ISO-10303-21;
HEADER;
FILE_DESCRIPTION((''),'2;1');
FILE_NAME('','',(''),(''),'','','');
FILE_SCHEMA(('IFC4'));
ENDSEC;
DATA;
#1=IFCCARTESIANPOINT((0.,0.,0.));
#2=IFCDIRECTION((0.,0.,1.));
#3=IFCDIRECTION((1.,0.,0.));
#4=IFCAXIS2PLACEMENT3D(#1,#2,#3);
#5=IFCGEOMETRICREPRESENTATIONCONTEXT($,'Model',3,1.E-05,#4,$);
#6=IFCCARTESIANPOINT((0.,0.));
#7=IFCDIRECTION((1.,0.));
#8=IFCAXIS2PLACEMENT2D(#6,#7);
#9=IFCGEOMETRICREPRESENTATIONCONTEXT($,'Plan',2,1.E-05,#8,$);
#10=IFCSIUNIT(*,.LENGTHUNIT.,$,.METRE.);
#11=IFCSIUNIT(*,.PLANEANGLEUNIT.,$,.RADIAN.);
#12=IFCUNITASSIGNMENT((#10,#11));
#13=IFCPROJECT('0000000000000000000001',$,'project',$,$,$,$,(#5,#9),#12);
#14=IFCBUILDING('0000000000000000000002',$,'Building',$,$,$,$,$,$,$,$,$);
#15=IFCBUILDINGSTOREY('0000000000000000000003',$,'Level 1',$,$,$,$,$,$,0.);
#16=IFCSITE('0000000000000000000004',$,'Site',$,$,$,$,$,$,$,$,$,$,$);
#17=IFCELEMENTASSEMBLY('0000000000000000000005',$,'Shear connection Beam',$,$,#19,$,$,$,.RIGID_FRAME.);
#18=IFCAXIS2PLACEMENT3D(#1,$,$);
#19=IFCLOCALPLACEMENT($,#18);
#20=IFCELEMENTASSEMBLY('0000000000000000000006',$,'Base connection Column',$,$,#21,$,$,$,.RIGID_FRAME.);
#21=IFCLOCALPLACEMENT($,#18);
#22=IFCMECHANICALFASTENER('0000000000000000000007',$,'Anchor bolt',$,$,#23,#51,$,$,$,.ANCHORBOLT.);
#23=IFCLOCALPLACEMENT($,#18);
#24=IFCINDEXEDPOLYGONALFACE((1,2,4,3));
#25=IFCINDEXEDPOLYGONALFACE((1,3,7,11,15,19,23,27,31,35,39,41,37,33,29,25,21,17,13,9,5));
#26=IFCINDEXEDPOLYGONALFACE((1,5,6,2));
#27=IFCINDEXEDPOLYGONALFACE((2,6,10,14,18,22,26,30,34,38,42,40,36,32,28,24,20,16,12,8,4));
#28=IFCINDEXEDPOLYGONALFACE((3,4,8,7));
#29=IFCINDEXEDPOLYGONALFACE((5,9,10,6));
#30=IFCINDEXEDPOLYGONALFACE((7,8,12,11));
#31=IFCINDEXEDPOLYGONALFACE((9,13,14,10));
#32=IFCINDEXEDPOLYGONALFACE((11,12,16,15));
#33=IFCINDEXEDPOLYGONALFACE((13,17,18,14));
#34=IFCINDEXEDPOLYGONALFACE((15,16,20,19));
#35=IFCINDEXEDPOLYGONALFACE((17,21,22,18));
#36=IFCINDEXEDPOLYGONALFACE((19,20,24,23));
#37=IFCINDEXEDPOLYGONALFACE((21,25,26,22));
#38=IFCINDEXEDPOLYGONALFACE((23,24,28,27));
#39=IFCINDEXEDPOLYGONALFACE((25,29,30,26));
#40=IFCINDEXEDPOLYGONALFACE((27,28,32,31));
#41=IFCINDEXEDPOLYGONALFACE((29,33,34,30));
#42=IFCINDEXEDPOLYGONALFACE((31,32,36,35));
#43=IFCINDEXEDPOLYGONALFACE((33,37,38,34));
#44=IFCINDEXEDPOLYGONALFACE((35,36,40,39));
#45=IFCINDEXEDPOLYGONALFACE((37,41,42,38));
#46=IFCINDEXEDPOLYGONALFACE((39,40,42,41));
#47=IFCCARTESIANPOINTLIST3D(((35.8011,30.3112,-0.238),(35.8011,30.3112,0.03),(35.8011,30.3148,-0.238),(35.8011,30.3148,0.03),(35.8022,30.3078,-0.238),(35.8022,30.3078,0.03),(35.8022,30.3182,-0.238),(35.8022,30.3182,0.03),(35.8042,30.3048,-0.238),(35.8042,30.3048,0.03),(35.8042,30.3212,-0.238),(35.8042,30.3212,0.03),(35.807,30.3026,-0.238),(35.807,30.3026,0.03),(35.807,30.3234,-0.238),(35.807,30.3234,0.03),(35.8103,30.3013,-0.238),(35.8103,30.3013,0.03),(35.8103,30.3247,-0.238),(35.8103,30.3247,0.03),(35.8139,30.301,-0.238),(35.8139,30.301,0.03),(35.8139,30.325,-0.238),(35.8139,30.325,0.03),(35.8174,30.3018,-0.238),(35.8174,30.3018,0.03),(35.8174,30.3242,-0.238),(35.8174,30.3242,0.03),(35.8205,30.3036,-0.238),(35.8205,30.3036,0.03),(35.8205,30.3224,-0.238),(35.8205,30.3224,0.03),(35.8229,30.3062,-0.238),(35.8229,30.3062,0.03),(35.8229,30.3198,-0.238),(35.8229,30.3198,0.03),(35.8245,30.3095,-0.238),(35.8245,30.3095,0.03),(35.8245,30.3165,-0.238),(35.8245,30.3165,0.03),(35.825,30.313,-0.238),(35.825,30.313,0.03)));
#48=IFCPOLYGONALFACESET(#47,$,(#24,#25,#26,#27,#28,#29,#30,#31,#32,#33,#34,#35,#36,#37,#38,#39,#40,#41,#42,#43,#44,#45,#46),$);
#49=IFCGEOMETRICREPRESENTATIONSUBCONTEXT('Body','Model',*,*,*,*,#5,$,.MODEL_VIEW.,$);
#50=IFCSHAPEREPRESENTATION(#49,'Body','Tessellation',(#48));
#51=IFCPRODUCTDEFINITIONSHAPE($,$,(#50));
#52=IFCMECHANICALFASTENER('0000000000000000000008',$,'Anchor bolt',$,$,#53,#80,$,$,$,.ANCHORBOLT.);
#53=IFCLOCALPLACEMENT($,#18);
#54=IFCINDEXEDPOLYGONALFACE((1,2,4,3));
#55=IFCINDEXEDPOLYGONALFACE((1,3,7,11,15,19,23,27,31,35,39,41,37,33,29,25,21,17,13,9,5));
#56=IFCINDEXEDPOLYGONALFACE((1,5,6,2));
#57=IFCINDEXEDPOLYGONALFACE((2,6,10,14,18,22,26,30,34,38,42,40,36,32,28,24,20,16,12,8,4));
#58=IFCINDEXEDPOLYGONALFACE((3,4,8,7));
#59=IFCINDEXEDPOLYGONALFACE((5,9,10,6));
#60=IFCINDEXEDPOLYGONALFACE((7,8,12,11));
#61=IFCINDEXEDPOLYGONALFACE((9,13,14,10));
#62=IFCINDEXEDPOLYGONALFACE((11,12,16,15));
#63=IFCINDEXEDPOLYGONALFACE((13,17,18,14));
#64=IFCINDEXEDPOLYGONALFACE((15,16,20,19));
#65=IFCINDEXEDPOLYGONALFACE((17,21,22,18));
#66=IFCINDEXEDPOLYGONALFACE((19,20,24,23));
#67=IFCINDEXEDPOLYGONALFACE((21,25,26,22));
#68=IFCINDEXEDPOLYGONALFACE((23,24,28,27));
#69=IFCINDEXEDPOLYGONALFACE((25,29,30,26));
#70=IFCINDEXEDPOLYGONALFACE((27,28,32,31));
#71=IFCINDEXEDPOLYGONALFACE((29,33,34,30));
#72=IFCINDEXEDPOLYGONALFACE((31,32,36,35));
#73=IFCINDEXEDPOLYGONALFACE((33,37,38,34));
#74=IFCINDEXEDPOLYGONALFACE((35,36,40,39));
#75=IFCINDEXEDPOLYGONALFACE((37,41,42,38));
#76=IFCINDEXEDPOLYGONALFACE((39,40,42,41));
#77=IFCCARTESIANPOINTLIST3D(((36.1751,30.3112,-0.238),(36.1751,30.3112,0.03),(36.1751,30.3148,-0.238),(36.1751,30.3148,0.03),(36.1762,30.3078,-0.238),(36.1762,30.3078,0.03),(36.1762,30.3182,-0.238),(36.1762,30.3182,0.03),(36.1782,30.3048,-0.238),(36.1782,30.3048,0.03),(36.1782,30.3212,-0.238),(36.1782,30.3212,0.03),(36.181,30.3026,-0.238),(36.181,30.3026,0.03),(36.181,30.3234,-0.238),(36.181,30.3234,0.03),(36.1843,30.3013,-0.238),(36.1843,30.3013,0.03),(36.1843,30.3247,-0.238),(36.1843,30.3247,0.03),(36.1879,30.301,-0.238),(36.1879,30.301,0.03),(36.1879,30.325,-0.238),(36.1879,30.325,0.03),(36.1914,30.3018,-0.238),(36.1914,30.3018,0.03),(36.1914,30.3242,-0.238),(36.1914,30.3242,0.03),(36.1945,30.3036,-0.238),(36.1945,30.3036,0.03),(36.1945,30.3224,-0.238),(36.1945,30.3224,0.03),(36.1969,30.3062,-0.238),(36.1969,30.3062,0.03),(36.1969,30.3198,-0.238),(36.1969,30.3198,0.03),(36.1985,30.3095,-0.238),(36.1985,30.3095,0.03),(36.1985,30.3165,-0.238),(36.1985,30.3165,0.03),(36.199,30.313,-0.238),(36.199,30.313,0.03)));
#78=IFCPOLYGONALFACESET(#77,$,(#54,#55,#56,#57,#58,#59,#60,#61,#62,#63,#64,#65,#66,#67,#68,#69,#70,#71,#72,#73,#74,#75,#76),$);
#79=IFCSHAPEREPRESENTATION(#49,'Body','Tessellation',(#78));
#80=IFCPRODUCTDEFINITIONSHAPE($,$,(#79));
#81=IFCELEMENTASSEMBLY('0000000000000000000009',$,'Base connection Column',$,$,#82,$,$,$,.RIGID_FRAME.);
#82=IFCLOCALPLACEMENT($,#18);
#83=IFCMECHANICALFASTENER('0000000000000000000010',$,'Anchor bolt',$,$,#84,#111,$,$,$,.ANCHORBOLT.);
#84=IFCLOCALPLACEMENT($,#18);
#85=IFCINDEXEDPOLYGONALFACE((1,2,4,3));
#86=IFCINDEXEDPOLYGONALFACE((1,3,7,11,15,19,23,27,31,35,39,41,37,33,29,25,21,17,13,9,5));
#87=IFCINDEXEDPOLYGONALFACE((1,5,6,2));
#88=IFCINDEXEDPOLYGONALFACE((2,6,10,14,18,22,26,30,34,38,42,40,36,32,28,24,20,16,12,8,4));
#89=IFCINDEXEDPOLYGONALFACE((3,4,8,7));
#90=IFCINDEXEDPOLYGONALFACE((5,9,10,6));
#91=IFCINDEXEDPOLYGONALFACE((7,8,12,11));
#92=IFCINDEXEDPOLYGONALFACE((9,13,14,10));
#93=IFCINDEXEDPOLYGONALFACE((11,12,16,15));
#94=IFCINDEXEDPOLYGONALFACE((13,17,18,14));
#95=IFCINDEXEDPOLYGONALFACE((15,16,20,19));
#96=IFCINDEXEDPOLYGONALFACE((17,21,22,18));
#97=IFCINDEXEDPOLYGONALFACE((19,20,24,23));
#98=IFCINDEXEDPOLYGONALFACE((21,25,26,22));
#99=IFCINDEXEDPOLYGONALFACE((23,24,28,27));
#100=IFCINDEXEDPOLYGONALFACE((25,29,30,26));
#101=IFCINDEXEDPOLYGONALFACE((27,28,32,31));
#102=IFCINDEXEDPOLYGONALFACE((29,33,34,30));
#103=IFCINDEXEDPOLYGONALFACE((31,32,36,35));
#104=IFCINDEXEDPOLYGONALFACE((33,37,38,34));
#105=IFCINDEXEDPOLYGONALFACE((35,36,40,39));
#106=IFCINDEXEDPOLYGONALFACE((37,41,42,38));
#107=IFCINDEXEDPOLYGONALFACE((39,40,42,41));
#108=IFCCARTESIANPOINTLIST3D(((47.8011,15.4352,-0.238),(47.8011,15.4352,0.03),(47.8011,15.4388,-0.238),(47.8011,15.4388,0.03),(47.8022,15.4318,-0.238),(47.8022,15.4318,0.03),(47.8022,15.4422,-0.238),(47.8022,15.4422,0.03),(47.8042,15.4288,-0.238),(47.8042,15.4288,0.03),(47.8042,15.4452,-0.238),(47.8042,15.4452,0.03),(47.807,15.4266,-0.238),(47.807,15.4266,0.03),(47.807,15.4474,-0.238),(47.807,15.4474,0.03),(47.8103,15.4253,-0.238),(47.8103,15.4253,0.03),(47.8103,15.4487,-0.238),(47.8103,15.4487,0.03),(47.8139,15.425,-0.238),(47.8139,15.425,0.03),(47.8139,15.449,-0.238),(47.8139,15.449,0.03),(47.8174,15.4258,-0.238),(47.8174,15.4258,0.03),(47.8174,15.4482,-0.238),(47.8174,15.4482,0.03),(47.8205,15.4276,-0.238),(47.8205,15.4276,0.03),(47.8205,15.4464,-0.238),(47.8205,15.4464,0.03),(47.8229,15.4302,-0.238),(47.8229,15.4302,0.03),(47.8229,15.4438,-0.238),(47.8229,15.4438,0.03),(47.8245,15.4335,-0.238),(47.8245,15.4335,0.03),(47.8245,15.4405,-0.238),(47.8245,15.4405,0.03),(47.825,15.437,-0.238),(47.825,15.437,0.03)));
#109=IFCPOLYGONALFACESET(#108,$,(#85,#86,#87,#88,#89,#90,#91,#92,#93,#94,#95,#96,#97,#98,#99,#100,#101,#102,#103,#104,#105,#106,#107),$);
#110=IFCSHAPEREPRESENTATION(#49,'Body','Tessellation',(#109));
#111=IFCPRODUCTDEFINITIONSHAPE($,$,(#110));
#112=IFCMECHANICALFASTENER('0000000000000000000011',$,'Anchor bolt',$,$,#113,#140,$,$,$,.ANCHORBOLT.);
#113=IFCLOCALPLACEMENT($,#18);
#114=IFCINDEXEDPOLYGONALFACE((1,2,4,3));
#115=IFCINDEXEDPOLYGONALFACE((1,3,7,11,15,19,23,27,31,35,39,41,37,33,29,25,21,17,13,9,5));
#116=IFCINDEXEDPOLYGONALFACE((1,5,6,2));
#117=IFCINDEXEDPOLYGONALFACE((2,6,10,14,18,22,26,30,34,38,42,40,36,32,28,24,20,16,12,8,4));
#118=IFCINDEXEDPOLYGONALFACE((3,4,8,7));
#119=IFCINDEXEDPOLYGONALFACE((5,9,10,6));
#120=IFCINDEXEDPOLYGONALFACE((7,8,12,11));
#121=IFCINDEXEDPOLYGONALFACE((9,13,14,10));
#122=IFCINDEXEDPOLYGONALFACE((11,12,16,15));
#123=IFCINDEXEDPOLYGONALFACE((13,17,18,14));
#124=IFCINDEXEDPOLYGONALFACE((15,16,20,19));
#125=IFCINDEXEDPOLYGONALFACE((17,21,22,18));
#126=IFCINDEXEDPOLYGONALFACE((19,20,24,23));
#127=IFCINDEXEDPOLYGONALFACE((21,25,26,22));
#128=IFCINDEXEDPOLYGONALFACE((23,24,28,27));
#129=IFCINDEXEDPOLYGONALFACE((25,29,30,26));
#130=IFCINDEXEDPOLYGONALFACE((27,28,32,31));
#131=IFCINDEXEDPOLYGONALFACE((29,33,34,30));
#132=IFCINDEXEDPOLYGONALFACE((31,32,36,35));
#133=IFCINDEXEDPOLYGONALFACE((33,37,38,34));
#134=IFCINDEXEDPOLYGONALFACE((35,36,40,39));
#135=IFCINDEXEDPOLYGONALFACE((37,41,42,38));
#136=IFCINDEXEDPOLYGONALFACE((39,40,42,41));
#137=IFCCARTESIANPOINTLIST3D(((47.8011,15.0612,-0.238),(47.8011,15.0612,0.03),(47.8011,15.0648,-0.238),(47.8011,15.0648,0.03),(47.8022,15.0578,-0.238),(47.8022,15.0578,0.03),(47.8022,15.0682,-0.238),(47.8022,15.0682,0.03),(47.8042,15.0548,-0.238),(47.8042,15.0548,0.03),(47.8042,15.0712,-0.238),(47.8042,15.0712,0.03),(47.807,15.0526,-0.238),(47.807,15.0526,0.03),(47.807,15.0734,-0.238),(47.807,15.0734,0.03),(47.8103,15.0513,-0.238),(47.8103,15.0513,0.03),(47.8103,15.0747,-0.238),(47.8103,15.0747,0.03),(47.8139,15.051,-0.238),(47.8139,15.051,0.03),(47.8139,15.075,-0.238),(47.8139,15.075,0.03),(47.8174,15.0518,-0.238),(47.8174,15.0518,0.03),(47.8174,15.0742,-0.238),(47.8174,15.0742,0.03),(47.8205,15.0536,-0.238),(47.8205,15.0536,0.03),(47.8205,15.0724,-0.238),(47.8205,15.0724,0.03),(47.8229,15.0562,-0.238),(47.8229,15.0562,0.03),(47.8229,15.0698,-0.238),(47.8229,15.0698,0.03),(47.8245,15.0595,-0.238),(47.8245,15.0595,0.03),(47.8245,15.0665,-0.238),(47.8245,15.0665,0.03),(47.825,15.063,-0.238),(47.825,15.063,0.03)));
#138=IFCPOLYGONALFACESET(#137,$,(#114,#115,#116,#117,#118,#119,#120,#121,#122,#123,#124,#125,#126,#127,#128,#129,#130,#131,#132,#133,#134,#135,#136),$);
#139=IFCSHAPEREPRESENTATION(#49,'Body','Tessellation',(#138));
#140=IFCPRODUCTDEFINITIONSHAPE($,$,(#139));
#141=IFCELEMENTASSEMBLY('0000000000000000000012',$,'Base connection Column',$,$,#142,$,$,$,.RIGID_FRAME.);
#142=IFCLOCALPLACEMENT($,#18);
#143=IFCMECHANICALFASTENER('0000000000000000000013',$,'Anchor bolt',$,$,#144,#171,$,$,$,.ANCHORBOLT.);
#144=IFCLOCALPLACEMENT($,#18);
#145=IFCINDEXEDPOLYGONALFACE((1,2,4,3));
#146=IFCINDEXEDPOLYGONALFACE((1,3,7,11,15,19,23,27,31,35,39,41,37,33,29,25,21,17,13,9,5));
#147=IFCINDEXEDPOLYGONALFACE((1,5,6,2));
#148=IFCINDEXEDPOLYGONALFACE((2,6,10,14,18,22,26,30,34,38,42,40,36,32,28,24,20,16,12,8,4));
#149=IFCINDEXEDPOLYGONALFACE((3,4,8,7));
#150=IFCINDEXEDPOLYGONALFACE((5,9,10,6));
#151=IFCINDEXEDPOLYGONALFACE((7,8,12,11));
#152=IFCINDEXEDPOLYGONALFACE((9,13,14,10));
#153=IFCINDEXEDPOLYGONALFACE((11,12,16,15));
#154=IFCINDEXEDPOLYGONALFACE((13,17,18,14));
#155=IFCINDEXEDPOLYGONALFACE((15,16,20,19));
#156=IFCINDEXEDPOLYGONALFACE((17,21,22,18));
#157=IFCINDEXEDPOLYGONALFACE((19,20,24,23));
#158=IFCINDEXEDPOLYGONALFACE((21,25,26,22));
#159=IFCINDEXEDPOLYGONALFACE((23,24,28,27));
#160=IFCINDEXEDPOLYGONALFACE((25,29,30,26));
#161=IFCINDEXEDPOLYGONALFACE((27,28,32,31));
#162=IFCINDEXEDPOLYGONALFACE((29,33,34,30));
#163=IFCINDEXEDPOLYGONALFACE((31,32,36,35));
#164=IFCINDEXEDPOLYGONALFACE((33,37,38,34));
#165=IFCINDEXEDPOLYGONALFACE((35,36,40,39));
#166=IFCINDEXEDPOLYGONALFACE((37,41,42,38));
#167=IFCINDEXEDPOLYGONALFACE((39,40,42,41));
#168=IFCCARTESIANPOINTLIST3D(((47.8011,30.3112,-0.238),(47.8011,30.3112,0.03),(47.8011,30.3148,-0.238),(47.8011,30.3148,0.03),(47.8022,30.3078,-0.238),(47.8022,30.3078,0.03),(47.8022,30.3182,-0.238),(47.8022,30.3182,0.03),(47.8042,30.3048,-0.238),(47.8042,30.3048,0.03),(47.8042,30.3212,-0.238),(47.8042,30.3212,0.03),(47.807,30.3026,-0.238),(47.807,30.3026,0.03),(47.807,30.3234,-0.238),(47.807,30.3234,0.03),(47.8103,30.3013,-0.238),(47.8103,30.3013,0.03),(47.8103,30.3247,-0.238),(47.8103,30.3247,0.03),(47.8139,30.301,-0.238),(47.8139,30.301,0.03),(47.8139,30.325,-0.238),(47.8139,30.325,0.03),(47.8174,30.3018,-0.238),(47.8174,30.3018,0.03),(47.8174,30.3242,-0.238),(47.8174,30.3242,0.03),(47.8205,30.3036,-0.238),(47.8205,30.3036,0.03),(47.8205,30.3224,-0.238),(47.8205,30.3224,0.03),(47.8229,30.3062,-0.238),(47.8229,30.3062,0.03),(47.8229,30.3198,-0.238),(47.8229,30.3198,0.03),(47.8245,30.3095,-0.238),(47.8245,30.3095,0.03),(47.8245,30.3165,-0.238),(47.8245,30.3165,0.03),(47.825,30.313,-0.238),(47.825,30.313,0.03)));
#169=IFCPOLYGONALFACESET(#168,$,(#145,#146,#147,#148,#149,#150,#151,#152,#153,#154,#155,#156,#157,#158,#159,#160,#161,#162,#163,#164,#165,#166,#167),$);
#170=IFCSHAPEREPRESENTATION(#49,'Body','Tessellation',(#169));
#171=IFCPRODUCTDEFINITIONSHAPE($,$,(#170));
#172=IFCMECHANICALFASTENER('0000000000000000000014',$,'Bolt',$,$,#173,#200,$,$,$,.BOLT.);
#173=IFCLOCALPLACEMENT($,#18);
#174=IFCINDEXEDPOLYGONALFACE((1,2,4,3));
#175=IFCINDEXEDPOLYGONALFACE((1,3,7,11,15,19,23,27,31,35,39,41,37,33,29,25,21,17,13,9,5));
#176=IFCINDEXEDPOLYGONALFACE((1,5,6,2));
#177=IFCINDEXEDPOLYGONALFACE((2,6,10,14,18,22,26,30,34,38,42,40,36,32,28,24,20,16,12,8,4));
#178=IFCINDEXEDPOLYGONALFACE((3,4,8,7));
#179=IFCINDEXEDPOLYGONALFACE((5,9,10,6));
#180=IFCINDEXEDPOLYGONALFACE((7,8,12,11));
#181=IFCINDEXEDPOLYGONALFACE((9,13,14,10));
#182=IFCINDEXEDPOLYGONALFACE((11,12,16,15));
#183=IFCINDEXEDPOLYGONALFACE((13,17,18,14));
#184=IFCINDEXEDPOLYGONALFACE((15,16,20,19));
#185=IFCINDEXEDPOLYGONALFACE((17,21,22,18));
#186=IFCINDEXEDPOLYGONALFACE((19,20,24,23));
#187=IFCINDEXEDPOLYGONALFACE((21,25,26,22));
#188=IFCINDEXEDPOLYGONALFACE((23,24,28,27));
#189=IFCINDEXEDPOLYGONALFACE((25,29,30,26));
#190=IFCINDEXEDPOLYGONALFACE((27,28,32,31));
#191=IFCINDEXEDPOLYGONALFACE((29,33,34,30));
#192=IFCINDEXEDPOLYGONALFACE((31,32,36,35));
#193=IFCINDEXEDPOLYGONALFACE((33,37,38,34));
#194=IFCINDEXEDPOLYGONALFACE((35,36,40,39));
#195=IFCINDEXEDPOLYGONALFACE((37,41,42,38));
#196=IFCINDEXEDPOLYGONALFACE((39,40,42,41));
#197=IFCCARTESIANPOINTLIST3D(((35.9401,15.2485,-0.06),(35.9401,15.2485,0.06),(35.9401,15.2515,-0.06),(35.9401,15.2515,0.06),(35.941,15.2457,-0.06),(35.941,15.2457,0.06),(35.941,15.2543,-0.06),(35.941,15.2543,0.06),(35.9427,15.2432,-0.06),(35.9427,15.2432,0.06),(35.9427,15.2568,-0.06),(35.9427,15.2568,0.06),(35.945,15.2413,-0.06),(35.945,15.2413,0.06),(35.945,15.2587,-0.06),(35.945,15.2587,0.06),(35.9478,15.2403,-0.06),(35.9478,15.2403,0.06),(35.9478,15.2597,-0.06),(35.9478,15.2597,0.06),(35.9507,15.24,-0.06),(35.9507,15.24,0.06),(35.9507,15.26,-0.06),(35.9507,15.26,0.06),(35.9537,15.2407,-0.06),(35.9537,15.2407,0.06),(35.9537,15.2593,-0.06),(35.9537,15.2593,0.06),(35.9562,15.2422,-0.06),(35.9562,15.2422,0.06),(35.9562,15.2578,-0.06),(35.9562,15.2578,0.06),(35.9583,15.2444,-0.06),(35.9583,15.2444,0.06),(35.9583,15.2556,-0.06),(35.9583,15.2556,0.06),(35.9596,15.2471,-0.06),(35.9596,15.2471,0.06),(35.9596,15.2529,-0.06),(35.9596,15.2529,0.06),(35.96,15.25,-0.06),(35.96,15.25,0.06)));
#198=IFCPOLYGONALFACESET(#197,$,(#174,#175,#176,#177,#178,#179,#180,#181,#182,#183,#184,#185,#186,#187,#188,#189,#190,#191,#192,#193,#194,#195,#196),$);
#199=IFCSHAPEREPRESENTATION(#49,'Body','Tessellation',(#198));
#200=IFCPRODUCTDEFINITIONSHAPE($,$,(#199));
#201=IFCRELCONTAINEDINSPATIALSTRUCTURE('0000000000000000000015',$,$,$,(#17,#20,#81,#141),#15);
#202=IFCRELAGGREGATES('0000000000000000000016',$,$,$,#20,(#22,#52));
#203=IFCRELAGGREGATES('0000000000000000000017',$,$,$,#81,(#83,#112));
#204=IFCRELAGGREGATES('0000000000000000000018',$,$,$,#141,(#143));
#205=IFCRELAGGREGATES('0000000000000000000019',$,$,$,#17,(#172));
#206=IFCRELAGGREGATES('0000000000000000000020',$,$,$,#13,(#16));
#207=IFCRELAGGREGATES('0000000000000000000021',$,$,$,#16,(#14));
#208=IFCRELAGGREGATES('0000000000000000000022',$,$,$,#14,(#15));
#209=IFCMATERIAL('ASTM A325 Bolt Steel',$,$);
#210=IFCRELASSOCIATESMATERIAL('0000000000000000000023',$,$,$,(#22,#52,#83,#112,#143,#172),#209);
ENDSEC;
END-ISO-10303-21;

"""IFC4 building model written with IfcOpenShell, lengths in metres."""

from ifc_helpers import new_model, si_unit, frame, origin_with_axes, origin_2d, origin_2d_with_axis, place, context, subcontext, project, spatial, circle, extrude, material, element, aggregate, save


model = new_model("IFC4")

# Units and contexts
model_context = context("Model", 3, precision=1e-05, world=origin_with_axes())
plan_context = context("Plan", 2, precision=1e-05, world=origin_2d_with_axis())
body_context = subcontext(model_context, "Body", "Model", "MODEL_VIEW")
ifc_project = project(units=[si_unit("LENGTHUNIT", "METRE"), si_unit("PLANEANGLEUNIT", "RADIAN")], contexts=[model_context, plan_context])

# Site, building, storey
site = spatial("IfcSite", under=ifc_project, Name="Site")
building = spatial("IfcBuilding", under=site, Name="Building")
storey = spatial("IfcBuildingStorey", under=building, Name="Level 1", Elevation=0.0)

# Element assembly
assembly_1 = element("IfcElementAssembly", 1, inside=storey, Name="Shear connection Beam", PredefinedType="RIGID_FRAME")

# Shared definitions
ifc_material_1 = material(Name="ASTM A325 Bolt Steel")

# Element assemblies, mechanical fasteners
assembly_2 = element("IfcElementAssembly", 2, inside=storey, Name="Base connection Column", PredefinedType="RIGID_FRAME")
mechanical_fastener_1_placement = place(None, frame((35.813, 30.313, -0.238), z_axis=(0.0, 0.0, 1.0), x_axis=(1.0, 0.0, 0.0)))
mechanical_fastener_1 = element("IfcMechanicalFastener", 3, at=mechanical_fastener_1_placement, material=ifc_material_1, Name="Anchor bolt", PredefinedType="ANCHORBOLT", context=body_context, shape_type="SweptSolid", body=[
    extrude(circle(Radius=0.012, at=origin_2d()), origin_with_axes(), (0.0, 0.0, 1.0), 0.268),
])
mechanical_fastener_2_placement = place(None, frame((36.187, 30.313, -0.238), z_axis=(0.0, 0.0, 1.0), x_axis=(1.0, 0.0, 0.0)))
mechanical_fastener_2 = element("IfcMechanicalFastener", 4, at=mechanical_fastener_2_placement, material=ifc_material_1, Name="Anchor bolt", PredefinedType="ANCHORBOLT", context=body_context, shape_type="SweptSolid", body=[
    extrude(circle(Radius=0.012, at=origin_2d()), origin_with_axes(), (0.0, 0.0, 1.0), 0.268),
])
aggregate(assembly_2, [mechanical_fastener_1, mechanical_fastener_2])
assembly_3 = element("IfcElementAssembly", 5, inside=storey, Name="Base connection Column", PredefinedType="RIGID_FRAME")
mechanical_fastener_3_placement = place(None, frame((47.813, 15.437, -0.238), z_axis=(0.0, 0.0, 1.0), x_axis=(1.0, 0.0, 0.0)))
mechanical_fastener_3 = element("IfcMechanicalFastener", 6, at=mechanical_fastener_3_placement, material=ifc_material_1, Name="Anchor bolt", PredefinedType="ANCHORBOLT", context=body_context, shape_type="SweptSolid", body=[
    extrude(circle(Radius=0.012, at=origin_2d()), origin_with_axes(), (0.0, 0.0, 1.0), 0.268),
])
mechanical_fastener_4_placement = place(None, frame((47.813, 15.063, -0.238), z_axis=(0.0, 0.0, 1.0), x_axis=(1.0, 0.0, 0.0)))
mechanical_fastener_4 = element("IfcMechanicalFastener", 7, at=mechanical_fastener_4_placement, material=ifc_material_1, Name="Anchor bolt", PredefinedType="ANCHORBOLT", context=body_context, shape_type="SweptSolid", body=[
    extrude(circle(Radius=0.012, at=origin_2d()), origin_with_axes(), (0.0, 0.0, 1.0), 0.268),
])
aggregate(assembly_3, [mechanical_fastener_3, mechanical_fastener_4])

# Element assembly, mechanical fastener
assembly_4 = element("IfcElementAssembly", 8, inside=storey, Name="Base connection Column", PredefinedType="RIGID_FRAME")
mechanical_fastener_5_placement = place(None, frame((47.813, 30.313, -0.238), z_axis=(0.0, 0.0, 1.0), x_axis=(1.0, 0.0, 0.0)))
mechanical_fastener_5 = element("IfcMechanicalFastener", 9, at=mechanical_fastener_5_placement, material=ifc_material_1, Name="Anchor bolt", PredefinedType="ANCHORBOLT", context=body_context, shape_type="SweptSolid", body=[
    extrude(circle(Radius=0.012, at=origin_2d()), origin_with_axes(), (0.0, 0.0, 1.0), 0.268),
])
aggregate(assembly_4, [mechanical_fastener_5])

# Mechanical fastener
mechanical_fastener_6_placement = place(None, frame((35.95, 15.25, -0.06), z_axis=(0.0, 0.0, 1.0), x_axis=(1.0, 0.0, 0.0)))
mechanical_fastener_6 = element("IfcMechanicalFastener", 10, at=mechanical_fastener_6_placement, material=ifc_material_1, Name="Bolt", PredefinedType="BOLT", context=body_context, shape_type="SweptSolid", body=[
    extrude(circle(Radius=0.01, at=origin_2d()), origin_with_axes(), (0.0, 0.0, 1.0), 0.12),
])
aggregate(assembly_1, [mechanical_fastener_6])

save(model, "model.ifc")
